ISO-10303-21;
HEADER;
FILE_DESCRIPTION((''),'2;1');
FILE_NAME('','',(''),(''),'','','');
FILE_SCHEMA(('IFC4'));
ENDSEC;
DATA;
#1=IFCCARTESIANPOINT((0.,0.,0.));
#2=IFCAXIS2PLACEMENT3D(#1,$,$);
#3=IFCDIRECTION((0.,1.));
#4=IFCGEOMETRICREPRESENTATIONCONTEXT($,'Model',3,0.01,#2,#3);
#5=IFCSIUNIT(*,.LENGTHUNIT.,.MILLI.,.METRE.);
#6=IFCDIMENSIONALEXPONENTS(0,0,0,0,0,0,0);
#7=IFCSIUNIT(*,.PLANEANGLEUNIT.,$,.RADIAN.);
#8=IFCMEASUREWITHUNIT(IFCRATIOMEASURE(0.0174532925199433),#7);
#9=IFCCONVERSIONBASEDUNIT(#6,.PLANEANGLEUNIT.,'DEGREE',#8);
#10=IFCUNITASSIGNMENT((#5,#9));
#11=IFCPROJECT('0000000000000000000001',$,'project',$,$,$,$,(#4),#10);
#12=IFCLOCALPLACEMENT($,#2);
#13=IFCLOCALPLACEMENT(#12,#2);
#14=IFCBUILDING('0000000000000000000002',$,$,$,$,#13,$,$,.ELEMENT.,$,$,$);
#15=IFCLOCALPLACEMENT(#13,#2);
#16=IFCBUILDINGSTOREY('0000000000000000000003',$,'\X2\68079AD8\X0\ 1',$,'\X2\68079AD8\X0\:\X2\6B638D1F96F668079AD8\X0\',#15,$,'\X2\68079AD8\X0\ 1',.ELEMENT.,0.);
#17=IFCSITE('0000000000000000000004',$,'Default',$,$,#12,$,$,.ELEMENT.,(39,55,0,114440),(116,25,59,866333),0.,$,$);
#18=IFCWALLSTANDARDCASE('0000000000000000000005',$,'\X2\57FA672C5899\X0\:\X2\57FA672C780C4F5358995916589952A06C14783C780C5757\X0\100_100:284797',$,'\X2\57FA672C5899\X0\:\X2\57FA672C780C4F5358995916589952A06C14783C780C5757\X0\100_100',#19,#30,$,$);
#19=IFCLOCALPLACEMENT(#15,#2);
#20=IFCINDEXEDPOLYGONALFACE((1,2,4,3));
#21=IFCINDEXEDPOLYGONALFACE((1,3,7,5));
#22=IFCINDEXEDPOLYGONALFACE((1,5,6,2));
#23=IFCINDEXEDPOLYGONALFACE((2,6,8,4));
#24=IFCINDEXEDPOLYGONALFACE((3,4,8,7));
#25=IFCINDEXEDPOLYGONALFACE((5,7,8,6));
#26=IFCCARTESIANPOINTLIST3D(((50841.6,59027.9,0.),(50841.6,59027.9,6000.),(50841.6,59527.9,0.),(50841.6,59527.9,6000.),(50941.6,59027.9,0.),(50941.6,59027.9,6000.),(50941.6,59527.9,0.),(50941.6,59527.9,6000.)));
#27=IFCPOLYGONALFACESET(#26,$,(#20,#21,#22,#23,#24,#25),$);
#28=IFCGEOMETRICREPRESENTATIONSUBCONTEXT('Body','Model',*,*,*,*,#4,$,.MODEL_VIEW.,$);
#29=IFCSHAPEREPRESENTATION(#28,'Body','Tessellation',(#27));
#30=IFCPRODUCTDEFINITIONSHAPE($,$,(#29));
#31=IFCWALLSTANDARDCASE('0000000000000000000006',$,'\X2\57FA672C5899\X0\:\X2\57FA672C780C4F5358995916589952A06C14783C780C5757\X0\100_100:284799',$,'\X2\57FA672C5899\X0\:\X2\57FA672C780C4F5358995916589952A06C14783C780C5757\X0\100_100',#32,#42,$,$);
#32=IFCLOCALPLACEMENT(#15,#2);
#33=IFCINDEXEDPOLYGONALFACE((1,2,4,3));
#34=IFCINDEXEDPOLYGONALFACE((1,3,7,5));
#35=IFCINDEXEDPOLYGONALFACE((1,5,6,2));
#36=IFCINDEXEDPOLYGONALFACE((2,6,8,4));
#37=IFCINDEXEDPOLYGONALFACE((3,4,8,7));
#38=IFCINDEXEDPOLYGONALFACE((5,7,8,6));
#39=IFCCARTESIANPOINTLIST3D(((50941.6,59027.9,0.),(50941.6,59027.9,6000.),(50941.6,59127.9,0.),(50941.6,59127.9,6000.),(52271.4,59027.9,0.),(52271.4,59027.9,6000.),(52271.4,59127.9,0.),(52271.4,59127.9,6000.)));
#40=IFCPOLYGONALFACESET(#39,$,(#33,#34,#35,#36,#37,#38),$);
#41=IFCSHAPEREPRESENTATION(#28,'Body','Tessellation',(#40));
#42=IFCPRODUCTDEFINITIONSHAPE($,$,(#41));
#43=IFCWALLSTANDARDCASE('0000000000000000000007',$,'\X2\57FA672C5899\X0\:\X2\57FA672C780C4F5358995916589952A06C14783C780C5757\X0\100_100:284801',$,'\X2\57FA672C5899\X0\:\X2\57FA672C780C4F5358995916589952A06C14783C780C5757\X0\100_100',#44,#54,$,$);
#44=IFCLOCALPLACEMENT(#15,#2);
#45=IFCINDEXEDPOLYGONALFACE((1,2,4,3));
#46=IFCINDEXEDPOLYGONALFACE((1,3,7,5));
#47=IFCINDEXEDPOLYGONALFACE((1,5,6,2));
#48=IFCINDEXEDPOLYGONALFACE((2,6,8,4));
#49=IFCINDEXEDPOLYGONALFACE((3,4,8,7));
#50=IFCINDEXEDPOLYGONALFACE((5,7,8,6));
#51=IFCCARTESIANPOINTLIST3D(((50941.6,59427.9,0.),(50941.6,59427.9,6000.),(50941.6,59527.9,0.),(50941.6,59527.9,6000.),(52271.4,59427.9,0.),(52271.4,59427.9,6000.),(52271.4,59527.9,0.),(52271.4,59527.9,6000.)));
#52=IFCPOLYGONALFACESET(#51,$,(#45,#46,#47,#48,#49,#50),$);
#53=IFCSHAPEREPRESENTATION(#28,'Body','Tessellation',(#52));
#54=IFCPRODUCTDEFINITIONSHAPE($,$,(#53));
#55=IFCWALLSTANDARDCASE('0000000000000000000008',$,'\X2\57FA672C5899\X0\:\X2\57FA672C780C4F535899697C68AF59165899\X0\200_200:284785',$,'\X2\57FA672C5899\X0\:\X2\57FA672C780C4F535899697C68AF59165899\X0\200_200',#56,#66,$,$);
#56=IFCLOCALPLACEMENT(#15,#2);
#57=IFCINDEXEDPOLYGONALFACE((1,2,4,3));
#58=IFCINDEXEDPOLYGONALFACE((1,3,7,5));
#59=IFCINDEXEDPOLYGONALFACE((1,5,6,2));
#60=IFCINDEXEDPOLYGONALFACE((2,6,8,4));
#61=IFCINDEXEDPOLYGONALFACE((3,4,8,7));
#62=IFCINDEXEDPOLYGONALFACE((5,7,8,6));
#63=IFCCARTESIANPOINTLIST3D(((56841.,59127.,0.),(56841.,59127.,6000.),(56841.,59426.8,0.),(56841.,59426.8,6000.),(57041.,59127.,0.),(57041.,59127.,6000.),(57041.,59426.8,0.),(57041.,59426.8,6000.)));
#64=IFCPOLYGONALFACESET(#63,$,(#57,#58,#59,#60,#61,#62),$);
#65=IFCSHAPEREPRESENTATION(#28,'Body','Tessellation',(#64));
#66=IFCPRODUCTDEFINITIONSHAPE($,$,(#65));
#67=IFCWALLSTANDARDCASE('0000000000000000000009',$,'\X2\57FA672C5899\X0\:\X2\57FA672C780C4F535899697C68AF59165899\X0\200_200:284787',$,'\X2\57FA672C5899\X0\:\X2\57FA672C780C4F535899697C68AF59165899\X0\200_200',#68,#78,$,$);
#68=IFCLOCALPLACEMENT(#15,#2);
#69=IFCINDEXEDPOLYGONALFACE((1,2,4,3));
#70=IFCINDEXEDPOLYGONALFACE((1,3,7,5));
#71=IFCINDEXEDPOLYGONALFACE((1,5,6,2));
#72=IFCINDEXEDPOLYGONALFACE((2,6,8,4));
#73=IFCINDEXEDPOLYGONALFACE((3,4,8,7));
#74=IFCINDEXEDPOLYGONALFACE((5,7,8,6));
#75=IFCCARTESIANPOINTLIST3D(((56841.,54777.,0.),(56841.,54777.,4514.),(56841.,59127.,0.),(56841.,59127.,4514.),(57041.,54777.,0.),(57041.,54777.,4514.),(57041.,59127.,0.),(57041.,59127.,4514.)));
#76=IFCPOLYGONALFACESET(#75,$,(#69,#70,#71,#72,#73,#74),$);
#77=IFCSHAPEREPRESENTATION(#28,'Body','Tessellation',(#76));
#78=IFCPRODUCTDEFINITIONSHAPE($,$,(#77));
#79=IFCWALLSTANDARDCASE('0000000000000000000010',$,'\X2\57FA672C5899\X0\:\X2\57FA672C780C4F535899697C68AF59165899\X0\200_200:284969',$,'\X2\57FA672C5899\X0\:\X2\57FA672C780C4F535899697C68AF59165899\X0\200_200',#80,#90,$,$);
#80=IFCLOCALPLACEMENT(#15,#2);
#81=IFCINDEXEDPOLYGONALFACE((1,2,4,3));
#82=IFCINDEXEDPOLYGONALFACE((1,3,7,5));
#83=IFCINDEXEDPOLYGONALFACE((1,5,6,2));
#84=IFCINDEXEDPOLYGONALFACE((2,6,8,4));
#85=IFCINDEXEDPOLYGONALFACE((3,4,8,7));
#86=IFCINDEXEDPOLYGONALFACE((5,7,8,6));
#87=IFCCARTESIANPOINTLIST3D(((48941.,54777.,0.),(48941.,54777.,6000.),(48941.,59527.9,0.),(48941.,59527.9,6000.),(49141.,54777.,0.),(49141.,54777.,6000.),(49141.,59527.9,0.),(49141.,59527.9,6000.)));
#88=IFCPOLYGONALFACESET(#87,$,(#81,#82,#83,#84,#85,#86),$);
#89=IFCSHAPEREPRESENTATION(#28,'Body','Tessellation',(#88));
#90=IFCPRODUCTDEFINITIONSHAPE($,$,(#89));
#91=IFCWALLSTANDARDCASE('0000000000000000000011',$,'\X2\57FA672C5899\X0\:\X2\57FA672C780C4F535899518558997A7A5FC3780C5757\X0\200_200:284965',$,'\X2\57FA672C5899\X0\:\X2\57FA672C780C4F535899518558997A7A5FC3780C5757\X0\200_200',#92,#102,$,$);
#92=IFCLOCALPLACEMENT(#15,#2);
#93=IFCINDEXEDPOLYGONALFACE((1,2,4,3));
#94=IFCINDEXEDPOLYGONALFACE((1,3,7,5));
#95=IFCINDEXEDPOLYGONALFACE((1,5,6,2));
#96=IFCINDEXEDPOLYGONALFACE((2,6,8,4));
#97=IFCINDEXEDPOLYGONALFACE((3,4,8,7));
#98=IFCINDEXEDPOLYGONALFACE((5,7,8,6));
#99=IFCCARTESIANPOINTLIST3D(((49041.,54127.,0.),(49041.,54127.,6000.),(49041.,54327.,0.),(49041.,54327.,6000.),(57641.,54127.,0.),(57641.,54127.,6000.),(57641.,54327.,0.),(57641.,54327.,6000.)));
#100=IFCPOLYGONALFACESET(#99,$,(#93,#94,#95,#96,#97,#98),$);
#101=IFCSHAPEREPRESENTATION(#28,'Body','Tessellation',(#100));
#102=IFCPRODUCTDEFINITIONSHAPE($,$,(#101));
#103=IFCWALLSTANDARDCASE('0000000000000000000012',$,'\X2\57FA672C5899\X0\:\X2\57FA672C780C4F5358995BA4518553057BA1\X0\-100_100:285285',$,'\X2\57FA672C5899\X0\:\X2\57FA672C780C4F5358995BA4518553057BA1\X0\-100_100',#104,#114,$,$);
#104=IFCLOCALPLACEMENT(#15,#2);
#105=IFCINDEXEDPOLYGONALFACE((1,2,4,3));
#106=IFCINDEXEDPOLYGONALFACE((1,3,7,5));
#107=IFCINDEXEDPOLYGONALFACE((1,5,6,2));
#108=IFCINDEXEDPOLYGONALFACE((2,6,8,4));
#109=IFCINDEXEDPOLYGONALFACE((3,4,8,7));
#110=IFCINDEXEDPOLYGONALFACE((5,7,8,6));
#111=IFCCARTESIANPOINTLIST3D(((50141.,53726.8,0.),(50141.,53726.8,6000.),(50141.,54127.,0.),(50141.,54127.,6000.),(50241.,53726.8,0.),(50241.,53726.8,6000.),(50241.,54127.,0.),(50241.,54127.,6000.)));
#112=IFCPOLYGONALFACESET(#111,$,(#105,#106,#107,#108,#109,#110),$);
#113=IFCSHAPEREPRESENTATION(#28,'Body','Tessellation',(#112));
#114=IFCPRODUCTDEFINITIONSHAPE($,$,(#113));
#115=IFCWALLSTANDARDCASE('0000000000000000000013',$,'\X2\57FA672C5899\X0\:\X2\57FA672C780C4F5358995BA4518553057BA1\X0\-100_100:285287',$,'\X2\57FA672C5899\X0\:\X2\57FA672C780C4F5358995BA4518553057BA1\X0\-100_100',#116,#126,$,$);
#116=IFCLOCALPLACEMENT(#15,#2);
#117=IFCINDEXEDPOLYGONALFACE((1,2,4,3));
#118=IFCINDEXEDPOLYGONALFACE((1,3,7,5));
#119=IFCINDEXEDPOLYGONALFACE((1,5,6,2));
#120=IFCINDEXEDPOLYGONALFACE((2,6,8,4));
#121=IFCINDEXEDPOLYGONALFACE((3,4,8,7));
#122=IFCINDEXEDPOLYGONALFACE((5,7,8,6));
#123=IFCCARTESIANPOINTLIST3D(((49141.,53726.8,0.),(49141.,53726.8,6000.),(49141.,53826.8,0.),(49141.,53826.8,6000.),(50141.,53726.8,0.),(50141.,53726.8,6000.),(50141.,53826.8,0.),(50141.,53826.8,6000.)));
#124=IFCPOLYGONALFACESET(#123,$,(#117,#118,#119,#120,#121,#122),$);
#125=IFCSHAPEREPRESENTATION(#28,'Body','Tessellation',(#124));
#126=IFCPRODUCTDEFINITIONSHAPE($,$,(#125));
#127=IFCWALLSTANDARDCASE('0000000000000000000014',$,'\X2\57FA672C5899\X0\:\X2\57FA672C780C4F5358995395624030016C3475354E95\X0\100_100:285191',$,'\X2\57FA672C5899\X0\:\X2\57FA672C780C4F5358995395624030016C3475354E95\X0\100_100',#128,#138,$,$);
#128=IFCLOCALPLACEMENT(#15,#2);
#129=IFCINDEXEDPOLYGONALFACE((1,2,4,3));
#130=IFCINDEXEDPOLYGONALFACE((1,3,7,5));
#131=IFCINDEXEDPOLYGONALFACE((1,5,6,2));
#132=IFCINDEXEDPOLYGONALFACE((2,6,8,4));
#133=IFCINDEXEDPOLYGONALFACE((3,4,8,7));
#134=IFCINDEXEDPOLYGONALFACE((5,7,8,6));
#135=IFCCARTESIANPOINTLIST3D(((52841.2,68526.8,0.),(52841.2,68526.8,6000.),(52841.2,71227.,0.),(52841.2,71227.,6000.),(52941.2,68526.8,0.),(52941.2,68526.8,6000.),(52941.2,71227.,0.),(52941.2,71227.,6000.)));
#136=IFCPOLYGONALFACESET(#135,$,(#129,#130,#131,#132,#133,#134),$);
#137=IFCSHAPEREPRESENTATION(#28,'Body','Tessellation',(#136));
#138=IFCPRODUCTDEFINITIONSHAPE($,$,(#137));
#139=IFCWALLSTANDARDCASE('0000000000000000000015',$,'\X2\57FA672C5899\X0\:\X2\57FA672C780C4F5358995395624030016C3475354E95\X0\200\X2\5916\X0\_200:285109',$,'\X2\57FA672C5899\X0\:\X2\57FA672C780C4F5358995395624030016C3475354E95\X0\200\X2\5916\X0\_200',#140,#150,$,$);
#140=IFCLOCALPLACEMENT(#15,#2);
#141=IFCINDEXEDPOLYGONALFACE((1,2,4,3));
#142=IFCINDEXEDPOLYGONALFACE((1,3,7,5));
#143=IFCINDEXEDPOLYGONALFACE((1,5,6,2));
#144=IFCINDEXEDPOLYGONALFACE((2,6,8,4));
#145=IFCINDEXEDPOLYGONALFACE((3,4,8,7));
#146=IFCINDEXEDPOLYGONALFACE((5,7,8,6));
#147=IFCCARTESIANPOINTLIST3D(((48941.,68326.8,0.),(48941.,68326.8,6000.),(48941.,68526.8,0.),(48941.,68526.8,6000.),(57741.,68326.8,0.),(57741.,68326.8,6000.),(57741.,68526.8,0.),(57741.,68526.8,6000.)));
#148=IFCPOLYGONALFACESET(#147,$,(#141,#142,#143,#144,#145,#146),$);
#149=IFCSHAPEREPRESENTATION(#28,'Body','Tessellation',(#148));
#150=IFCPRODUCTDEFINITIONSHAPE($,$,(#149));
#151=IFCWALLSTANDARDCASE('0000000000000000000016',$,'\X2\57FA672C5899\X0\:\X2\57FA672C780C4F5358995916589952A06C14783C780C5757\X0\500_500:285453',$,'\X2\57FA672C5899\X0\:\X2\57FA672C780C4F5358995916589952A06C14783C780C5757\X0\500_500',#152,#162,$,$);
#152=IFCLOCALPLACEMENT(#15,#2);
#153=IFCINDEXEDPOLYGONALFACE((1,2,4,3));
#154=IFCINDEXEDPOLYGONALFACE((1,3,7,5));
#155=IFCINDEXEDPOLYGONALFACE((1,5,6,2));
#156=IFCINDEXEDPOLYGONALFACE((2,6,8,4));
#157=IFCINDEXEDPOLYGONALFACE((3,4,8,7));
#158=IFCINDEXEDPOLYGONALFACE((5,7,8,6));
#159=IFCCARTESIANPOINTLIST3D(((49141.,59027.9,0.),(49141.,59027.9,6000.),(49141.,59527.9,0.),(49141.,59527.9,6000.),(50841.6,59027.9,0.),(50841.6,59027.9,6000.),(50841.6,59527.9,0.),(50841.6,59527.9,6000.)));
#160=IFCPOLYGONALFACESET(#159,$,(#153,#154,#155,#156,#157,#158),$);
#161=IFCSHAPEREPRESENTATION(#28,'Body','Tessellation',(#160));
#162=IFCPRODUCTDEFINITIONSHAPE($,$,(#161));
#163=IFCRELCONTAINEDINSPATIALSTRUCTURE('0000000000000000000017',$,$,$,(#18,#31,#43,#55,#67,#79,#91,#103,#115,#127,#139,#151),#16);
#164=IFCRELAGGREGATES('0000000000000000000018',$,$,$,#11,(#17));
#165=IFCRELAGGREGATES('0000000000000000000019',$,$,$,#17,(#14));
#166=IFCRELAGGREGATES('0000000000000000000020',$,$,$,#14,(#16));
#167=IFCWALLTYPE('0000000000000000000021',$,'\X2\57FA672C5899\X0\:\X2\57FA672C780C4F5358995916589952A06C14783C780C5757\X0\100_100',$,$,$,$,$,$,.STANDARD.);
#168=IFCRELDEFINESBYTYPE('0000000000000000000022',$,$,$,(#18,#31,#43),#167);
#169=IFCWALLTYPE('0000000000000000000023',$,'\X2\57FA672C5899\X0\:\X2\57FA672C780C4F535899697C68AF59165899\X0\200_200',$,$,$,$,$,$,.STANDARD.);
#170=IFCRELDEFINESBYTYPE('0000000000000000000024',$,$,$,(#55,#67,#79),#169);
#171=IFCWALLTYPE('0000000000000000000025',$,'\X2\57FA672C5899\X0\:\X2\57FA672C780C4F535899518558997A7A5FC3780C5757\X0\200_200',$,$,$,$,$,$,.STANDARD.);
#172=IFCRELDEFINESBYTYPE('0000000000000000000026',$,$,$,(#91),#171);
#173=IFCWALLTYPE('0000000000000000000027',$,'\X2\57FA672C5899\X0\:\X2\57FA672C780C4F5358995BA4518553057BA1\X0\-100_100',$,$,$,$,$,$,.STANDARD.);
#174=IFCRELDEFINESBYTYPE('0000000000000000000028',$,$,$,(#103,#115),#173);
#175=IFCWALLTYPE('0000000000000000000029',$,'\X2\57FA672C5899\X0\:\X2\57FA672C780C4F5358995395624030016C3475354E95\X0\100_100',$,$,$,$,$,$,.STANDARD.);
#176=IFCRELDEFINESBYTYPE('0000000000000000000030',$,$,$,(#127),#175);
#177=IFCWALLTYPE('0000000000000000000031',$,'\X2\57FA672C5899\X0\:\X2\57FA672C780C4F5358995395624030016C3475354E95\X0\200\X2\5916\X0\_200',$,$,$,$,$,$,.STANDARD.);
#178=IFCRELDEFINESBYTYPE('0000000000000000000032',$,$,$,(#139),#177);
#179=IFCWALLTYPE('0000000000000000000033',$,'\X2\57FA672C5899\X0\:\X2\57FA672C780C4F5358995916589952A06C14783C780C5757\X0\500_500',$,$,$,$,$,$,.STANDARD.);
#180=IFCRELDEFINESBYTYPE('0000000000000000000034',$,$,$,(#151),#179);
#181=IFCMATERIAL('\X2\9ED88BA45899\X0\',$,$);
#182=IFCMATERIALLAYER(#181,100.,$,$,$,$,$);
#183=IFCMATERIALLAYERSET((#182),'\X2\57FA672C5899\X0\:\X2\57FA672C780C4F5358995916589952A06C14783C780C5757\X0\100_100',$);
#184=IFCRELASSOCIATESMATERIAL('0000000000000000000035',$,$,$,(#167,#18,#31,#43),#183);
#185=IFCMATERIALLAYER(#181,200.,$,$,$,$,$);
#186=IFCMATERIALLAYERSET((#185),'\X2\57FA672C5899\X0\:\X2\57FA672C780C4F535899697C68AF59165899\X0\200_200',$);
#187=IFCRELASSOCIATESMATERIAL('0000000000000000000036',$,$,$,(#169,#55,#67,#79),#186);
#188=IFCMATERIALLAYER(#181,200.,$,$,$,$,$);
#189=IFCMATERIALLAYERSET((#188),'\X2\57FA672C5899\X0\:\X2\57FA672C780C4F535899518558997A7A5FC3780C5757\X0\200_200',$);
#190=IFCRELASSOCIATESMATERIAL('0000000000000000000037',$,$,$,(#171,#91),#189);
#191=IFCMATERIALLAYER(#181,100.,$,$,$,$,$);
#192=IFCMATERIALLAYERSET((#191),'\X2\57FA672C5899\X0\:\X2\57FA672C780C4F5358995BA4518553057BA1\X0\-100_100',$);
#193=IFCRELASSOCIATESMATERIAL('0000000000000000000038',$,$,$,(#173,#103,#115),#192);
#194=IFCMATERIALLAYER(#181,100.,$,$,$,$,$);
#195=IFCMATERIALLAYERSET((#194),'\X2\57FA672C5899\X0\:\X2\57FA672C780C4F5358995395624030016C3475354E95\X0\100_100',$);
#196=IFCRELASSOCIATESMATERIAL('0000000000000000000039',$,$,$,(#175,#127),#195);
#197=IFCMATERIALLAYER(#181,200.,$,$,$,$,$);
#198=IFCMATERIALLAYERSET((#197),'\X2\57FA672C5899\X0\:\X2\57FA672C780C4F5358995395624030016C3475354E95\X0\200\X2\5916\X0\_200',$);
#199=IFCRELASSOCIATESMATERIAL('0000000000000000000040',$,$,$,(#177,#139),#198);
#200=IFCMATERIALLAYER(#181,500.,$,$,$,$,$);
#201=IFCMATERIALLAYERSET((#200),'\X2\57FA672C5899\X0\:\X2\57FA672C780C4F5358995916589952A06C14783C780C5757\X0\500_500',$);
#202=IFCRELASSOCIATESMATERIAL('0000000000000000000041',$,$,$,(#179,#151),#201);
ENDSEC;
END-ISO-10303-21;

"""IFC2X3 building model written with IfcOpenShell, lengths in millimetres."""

from ifc_helpers import new_model, entity, si_unit, converted_unit, direction, frame, frame_2d, origin, place, context, subcontext, project, spatial, rectangle, extrude, material, layer, layer_set, layer_usage, type_object, element, save


model = new_model("IFC2X3")

# Units and contexts
model_context = context("Model", 3, precision=0.01, world=origin(), true_north=direction((0.0, 1.0)))
body_context = subcontext(model_context, "Body", "Model", "MODEL_VIEW")
ifc_project = project(units=[si_unit("LENGTHUNIT", "METRE", prefix="MILLI"), converted_unit("PLANEANGLEUNIT", "DEGREE", entity("IfcRatioMeasure", 0.0174532925199433), si_unit("PLANEANGLEUNIT", "RADIAN"), dimensions=[0, 0, 0, 0, 0, 0, 0])], contexts=[model_context])

# Site, building, storey
site_placement = place(None, origin())
site = spatial("IfcSite", under=ifc_project, at=site_placement, Name="Default", CompositionType="ELEMENT", RefLatitude=(39, 55, 0, 114440), RefLongitude=(116, 25, 59, 866333), RefElevation=0.0)
building_placement = place(site_placement, origin())
building = spatial("IfcBuilding", under=site, at=building_placement, CompositionType="ELEMENT")
storey_placement = place(building_placement, origin())
storey = spatial("IfcBuildingStorey", under=building, at=storey_placement, Name="标高 1", ObjectType="标高:正负零标高", LongName="标高 1", CompositionType="ELEMENT", Elevation=0.0)

# Walls
ifc_material = material(Name="默认墙")
ifc_layer_1 = layer(ifc_material, 100.0)
ifc_layer_set_1 = layer_set([ifc_layer_1], Name="基本墙:基本砌体墙外墙加气砼砌块100_100")
wall_type_1 = type_object("IfcWallType", Name="基本墙:基本砌体墙外墙加气砼砌块100_100", PredefinedType="STANDARD", material=ifc_layer_set_1)
ifc_layer_usage_1 = layer_usage(ifc_layer_set_1, "AXIS2", "NEGATIVE", 50.0)
wall_1_placement = place(building_placement, frame((50891.6, 59027.9, 0.0), z_axis=(0.0, 0.0, 1.0), x_axis=(0.0, 1.0, 0.0)))
element("IfcWallStandardCase", 1, at=wall_1_placement, inside=storey, type_object=wall_type_1, material=ifc_layer_usage_1, Name="基本墙:基本砌体墙外墙加气砼砌块100_100:284797", ObjectType="基本墙:基本砌体墙外墙加气砼砌块100_100", context=body_context, shape_type="SweptSolid", body=[
    extrude(rectangle(XDim=500.0, YDim=100.0, at=frame_2d((250.0, 0.0), x_axis=(-1.0, 0.0))), origin(), (0.0, 0.0, 1.0), 6000.0),
])
ifc_layer_usage_2 = layer_usage(ifc_layer_set_1, "AXIS2", "NEGATIVE", 50.0)
wall_2_placement = place(building_placement, frame((50941.6, 59077.9, 0.0)))
element("IfcWallStandardCase", 2, at=wall_2_placement, inside=storey, type_object=wall_type_1, material=ifc_layer_usage_2, Name="基本墙:基本砌体墙外墙加气砼砌块100_100:284799", ObjectType="基本墙:基本砌体墙外墙加气砼砌块100_100", context=body_context, shape_type="SweptSolid", body=[
    extrude(rectangle(XDim=1329.9, YDim=100.0, at=frame_2d((664.9, 0.0), x_axis=(-1.0, 0.0))), origin(), (0.0, 0.0, 1.0), 6000.0),
])
ifc_layer_usage_3 = layer_usage(ifc_layer_set_1, "AXIS2", "NEGATIVE", 50.0)
wall_3_placement = place(building_placement, frame((50941.6, 59477.9, 0.0)))
element("IfcWallStandardCase", 3, at=wall_3_placement, inside=storey, type_object=wall_type_1, material=ifc_layer_usage_3, Name="基本墙:基本砌体墙外墙加气砼砌块100_100:284801", ObjectType="基本墙:基本砌体墙外墙加气砼砌块100_100", context=body_context, shape_type="SweptSolid", body=[
    extrude(rectangle(XDim=1329.9, YDim=100.0, at=frame_2d((664.9, 0.0), x_axis=(-1.0, 0.0))), origin(), (0.0, 0.0, 1.0), 6000.0),
])
ifc_layer_2 = layer(ifc_material, 200.0)
ifc_layer_set_2 = layer_set([ifc_layer_2], Name="基本墙:基本砌体墙楼梯外墙200_200")
ifc_layer_usage_4 = layer_usage(ifc_layer_set_2, "AXIS2", "NEGATIVE", 100.0)
wall_type_2 = type_object("IfcWallType", Name="基本墙:基本砌体墙楼梯外墙200_200", PredefinedType="STANDARD", material=ifc_layer_set_2)
wall_4_placement = place(building_placement, frame((56941.0, 59426.8, 0.0), z_axis=(0.0, 0.0, 1.0), x_axis=(0.0, -1.0, 0.0)))
element("IfcWallStandardCase", 4, at=wall_4_placement, inside=storey, type_object=wall_type_2, material=ifc_layer_usage_4, Name="基本墙:基本砌体墙楼梯外墙200_200:284785", ObjectType="基本墙:基本砌体墙楼梯外墙200_200", context=body_context, shape_type="SweptSolid", body=[
    extrude(rectangle(XDim=299.8, YDim=200.0, at=frame_2d((149.9, 0.0), x_axis=(-1.0, 0.0))), origin(), (0.0, 0.0, 1.0), 6000.0),
])
ifc_layer_usage_5 = layer_usage(ifc_layer_set_2, "AXIS2", "NEGATIVE", 100.0)
wall_5_placement = place(building_placement, frame((56941.0, 59127.0, 0.0), z_axis=(0.0, 0.0, 1.0), x_axis=(0.0, -1.0, 0.0)))
element("IfcWallStandardCase", 5, at=wall_5_placement, inside=storey, type_object=wall_type_2, material=ifc_layer_usage_5, Name="基本墙:基本砌体墙楼梯外墙200_200:284787", ObjectType="基本墙:基本砌体墙楼梯外墙200_200", context=body_context, shape_type="SweptSolid", body=[
    extrude(rectangle(XDim=4350.0, YDim=200.0, at=frame_2d((2175.0, 0.0), x_axis=(-1.0, 0.0))), origin(), (0.0, 0.0, 1.0), 4514.0),
])
ifc_layer_usage_6 = layer_usage(ifc_layer_set_2, "AXIS2", "NEGATIVE", 100.0)
wall_6_placement = place(building_placement, frame((49041.0, 54777.0, 0.0), z_axis=(0.0, 0.0, 1.0), x_axis=(0.0, 1.0, 0.0)))
element("IfcWallStandardCase", 6, at=wall_6_placement, inside=storey, type_object=wall_type_2, material=ifc_layer_usage_6, Name="基本墙:基本砌体墙楼梯外墙200_200:284969", ObjectType="基本墙:基本砌体墙楼梯外墙200_200", context=body_context, shape_type="SweptSolid", body=[
    extrude(rectangle(XDim=4750.9, YDim=200.0, at=frame_2d((2375.4, 0.0), x_axis=(-1.0, 0.0))), origin(), (0.0, 0.0, 1.0), 6000.0),
])
ifc_layer_3 = layer(ifc_material, 200.0)
ifc_layer_set_3 = layer_set([ifc_layer_3], Name="基本墙:基本砌体墙内墙空心砌块200_200")
ifc_layer_usage_7 = layer_usage(ifc_layer_set_3, "AXIS2", "NEGATIVE", 100.0)
wall_type_3 = type_object("IfcWallType", Name="基本墙:基本砌体墙内墙空心砌块200_200", PredefinedType="STANDARD", material=ifc_layer_set_3)
wall_7_placement = place(building_placement, frame((49041.0, 54227.0, 0.0)))
element("IfcWallStandardCase", 7, at=wall_7_placement, inside=storey, type_object=wall_type_3, material=ifc_layer_usage_7, Name="基本墙:基本砌体墙内墙空心砌块200_200:284965", ObjectType="基本墙:基本砌体墙内墙空心砌块200_200", context=body_context, shape_type="SweptSolid", body=[
    extrude(rectangle(XDim=8600.0, YDim=200.0, at=frame_2d((4300.0, 0.0), x_axis=(-1.0, 0.0))), origin(), (0.0, 0.0, 1.0), 6000.0),
])
ifc_layer_4 = layer(ifc_material, 100.0)
ifc_layer_set_4 = layer_set([ifc_layer_4], Name="基本墙:基本砌体墙室内包管-100_100")
ifc_layer_usage_8 = layer_usage(ifc_layer_set_4, "AXIS2", "NEGATIVE", 50.0)
wall_type_4 = type_object("IfcWallType", Name="基本墙:基本砌体墙室内包管-100_100", PredefinedType="STANDARD", material=ifc_layer_set_4)
wall_8_placement = place(building_placement, frame((50191.0, 53726.8, 0.0), z_axis=(0.0, 0.0, 1.0), x_axis=(0.0, 1.0, 0.0)))
element("IfcWallStandardCase", 8, at=wall_8_placement, inside=storey, type_object=wall_type_4, material=ifc_layer_usage_8, Name="基本墙:基本砌体墙室内包管-100_100:285285", ObjectType="基本墙:基本砌体墙室内包管-100_100", context=body_context, shape_type="SweptSolid", body=[
    extrude(rectangle(XDim=400.2, YDim=100.0, at=frame_2d((200.1, 0.0), x_axis=(-1.0, 0.0))), origin(), (0.0, 0.0, 1.0), 6000.0),
])
ifc_layer_usage_9 = layer_usage(ifc_layer_set_4, "AXIS2", "NEGATIVE", 50.0)
wall_9_placement = place(building_placement, frame((50141.0, 53776.8, 0.0), z_axis=(0.0, 0.0, 1.0), x_axis=(-1.0, 0.0, 0.0)))
element("IfcWallStandardCase", 9, at=wall_9_placement, inside=storey, type_object=wall_type_4, material=ifc_layer_usage_9, Name="基本墙:基本砌体墙室内包管-100_100:285287", ObjectType="基本墙:基本砌体墙室内包管-100_100", context=body_context, shape_type="SweptSolid", body=[
    extrude(rectangle(XDim=1000.0, YDim=100.0, at=frame_2d((500.0, 0.0), x_axis=(-1.0, 0.0))), origin(), (0.0, 0.0, 1.0), 6000.0),
])
ifc_layer_5 = layer(ifc_material, 100.0)
ifc_layer_set_5 = layer_set([ifc_layer_5], Name="基本墙:基本砌体墙厕所、水电井100_100")
ifc_layer_usage_10 = layer_usage(ifc_layer_set_5, "AXIS2", "NEGATIVE", 50.0)
wall_type_5 = type_object("IfcWallType", Name="基本墙:基本砌体墙厕所、水电井100_100", PredefinedType="STANDARD", material=ifc_layer_set_5)
wall_10_placement = place(building_placement, frame((52891.2, 68526.8, 0.0), z_axis=(0.0, 0.0, 1.0), x_axis=(0.0, 1.0, 0.0)))
element("IfcWallStandardCase", 10, at=wall_10_placement, inside=storey, type_object=wall_type_5, material=ifc_layer_usage_10, Name="基本墙:基本砌体墙厕所、水电井100_100:285191", ObjectType="基本墙:基本砌体墙厕所、水电井100_100", context=body_context, shape_type="SweptSolid", body=[
    extrude(rectangle(XDim=2700.2, YDim=100.0, at=frame_2d((1350.1, 0.0), x_axis=(-1.0, 0.0))), origin(), (0.0, 0.0, 1.0), 6000.0),
])
ifc_layer_6 = layer(ifc_material, 200.0)
ifc_layer_set_6 = layer_set([ifc_layer_6], Name="基本墙:基本砌体墙厕所、水电井200外_200")
ifc_layer_usage_11 = layer_usage(ifc_layer_set_6, "AXIS2", "NEGATIVE", 100.0)
wall_type_6 = type_object("IfcWallType", Name="基本墙:基本砌体墙厕所、水电井200外_200", PredefinedType="STANDARD", material=ifc_layer_set_6)
wall_11_placement = place(building_placement, frame((48941.0, 68426.8, 0.0)))
element("IfcWallStandardCase", 11, at=wall_11_placement, inside=storey, type_object=wall_type_6, material=ifc_layer_usage_11, Name="基本墙:基本砌体墙厕所、水电井200外_200:285109", ObjectType="基本墙:基本砌体墙厕所、水电井200外_200", context=body_context, shape_type="SweptSolid", body=[
    extrude(rectangle(XDim=8800.0, YDim=200.0, at=frame_2d((4400.0, 0.0), x_axis=(-1.0, 0.0))), origin(), (0.0, 0.0, 1.0), 6000.0),
])
ifc_layer_7 = layer(ifc_material, 500.0)
ifc_layer_set_7 = layer_set([ifc_layer_7], Name="基本墙:基本砌体墙外墙加气砼砌块500_500")
ifc_layer_usage_12 = layer_usage(ifc_layer_set_7, "AXIS2", "NEGATIVE", 250.0)
wall_type_7 = type_object("IfcWallType", Name="基本墙:基本砌体墙外墙加气砼砌块500_500", PredefinedType="STANDARD", material=ifc_layer_set_7)
wall_12_placement = place(building_placement, frame((50841.6, 59277.9, 0.0), z_axis=(0.0, 0.0, 1.0), x_axis=(-1.0, 0.0, 0.0)))
element("IfcWallStandardCase", 12, at=wall_12_placement, inside=storey, type_object=wall_type_7, material=ifc_layer_usage_12, Name="基本墙:基本砌体墙外墙加气砼砌块500_500:285453", ObjectType="基本墙:基本砌体墙外墙加气砼砌块500_500", context=body_context, shape_type="SweptSolid", body=[
    extrude(rectangle(XDim=1700.6, YDim=500.0, at=frame_2d((850.3, 0.0), x_axis=(-1.0, 0.0))), origin(), (0.0, 0.0, 1.0), 6000.0),
])

save(model, "model.ifc")
